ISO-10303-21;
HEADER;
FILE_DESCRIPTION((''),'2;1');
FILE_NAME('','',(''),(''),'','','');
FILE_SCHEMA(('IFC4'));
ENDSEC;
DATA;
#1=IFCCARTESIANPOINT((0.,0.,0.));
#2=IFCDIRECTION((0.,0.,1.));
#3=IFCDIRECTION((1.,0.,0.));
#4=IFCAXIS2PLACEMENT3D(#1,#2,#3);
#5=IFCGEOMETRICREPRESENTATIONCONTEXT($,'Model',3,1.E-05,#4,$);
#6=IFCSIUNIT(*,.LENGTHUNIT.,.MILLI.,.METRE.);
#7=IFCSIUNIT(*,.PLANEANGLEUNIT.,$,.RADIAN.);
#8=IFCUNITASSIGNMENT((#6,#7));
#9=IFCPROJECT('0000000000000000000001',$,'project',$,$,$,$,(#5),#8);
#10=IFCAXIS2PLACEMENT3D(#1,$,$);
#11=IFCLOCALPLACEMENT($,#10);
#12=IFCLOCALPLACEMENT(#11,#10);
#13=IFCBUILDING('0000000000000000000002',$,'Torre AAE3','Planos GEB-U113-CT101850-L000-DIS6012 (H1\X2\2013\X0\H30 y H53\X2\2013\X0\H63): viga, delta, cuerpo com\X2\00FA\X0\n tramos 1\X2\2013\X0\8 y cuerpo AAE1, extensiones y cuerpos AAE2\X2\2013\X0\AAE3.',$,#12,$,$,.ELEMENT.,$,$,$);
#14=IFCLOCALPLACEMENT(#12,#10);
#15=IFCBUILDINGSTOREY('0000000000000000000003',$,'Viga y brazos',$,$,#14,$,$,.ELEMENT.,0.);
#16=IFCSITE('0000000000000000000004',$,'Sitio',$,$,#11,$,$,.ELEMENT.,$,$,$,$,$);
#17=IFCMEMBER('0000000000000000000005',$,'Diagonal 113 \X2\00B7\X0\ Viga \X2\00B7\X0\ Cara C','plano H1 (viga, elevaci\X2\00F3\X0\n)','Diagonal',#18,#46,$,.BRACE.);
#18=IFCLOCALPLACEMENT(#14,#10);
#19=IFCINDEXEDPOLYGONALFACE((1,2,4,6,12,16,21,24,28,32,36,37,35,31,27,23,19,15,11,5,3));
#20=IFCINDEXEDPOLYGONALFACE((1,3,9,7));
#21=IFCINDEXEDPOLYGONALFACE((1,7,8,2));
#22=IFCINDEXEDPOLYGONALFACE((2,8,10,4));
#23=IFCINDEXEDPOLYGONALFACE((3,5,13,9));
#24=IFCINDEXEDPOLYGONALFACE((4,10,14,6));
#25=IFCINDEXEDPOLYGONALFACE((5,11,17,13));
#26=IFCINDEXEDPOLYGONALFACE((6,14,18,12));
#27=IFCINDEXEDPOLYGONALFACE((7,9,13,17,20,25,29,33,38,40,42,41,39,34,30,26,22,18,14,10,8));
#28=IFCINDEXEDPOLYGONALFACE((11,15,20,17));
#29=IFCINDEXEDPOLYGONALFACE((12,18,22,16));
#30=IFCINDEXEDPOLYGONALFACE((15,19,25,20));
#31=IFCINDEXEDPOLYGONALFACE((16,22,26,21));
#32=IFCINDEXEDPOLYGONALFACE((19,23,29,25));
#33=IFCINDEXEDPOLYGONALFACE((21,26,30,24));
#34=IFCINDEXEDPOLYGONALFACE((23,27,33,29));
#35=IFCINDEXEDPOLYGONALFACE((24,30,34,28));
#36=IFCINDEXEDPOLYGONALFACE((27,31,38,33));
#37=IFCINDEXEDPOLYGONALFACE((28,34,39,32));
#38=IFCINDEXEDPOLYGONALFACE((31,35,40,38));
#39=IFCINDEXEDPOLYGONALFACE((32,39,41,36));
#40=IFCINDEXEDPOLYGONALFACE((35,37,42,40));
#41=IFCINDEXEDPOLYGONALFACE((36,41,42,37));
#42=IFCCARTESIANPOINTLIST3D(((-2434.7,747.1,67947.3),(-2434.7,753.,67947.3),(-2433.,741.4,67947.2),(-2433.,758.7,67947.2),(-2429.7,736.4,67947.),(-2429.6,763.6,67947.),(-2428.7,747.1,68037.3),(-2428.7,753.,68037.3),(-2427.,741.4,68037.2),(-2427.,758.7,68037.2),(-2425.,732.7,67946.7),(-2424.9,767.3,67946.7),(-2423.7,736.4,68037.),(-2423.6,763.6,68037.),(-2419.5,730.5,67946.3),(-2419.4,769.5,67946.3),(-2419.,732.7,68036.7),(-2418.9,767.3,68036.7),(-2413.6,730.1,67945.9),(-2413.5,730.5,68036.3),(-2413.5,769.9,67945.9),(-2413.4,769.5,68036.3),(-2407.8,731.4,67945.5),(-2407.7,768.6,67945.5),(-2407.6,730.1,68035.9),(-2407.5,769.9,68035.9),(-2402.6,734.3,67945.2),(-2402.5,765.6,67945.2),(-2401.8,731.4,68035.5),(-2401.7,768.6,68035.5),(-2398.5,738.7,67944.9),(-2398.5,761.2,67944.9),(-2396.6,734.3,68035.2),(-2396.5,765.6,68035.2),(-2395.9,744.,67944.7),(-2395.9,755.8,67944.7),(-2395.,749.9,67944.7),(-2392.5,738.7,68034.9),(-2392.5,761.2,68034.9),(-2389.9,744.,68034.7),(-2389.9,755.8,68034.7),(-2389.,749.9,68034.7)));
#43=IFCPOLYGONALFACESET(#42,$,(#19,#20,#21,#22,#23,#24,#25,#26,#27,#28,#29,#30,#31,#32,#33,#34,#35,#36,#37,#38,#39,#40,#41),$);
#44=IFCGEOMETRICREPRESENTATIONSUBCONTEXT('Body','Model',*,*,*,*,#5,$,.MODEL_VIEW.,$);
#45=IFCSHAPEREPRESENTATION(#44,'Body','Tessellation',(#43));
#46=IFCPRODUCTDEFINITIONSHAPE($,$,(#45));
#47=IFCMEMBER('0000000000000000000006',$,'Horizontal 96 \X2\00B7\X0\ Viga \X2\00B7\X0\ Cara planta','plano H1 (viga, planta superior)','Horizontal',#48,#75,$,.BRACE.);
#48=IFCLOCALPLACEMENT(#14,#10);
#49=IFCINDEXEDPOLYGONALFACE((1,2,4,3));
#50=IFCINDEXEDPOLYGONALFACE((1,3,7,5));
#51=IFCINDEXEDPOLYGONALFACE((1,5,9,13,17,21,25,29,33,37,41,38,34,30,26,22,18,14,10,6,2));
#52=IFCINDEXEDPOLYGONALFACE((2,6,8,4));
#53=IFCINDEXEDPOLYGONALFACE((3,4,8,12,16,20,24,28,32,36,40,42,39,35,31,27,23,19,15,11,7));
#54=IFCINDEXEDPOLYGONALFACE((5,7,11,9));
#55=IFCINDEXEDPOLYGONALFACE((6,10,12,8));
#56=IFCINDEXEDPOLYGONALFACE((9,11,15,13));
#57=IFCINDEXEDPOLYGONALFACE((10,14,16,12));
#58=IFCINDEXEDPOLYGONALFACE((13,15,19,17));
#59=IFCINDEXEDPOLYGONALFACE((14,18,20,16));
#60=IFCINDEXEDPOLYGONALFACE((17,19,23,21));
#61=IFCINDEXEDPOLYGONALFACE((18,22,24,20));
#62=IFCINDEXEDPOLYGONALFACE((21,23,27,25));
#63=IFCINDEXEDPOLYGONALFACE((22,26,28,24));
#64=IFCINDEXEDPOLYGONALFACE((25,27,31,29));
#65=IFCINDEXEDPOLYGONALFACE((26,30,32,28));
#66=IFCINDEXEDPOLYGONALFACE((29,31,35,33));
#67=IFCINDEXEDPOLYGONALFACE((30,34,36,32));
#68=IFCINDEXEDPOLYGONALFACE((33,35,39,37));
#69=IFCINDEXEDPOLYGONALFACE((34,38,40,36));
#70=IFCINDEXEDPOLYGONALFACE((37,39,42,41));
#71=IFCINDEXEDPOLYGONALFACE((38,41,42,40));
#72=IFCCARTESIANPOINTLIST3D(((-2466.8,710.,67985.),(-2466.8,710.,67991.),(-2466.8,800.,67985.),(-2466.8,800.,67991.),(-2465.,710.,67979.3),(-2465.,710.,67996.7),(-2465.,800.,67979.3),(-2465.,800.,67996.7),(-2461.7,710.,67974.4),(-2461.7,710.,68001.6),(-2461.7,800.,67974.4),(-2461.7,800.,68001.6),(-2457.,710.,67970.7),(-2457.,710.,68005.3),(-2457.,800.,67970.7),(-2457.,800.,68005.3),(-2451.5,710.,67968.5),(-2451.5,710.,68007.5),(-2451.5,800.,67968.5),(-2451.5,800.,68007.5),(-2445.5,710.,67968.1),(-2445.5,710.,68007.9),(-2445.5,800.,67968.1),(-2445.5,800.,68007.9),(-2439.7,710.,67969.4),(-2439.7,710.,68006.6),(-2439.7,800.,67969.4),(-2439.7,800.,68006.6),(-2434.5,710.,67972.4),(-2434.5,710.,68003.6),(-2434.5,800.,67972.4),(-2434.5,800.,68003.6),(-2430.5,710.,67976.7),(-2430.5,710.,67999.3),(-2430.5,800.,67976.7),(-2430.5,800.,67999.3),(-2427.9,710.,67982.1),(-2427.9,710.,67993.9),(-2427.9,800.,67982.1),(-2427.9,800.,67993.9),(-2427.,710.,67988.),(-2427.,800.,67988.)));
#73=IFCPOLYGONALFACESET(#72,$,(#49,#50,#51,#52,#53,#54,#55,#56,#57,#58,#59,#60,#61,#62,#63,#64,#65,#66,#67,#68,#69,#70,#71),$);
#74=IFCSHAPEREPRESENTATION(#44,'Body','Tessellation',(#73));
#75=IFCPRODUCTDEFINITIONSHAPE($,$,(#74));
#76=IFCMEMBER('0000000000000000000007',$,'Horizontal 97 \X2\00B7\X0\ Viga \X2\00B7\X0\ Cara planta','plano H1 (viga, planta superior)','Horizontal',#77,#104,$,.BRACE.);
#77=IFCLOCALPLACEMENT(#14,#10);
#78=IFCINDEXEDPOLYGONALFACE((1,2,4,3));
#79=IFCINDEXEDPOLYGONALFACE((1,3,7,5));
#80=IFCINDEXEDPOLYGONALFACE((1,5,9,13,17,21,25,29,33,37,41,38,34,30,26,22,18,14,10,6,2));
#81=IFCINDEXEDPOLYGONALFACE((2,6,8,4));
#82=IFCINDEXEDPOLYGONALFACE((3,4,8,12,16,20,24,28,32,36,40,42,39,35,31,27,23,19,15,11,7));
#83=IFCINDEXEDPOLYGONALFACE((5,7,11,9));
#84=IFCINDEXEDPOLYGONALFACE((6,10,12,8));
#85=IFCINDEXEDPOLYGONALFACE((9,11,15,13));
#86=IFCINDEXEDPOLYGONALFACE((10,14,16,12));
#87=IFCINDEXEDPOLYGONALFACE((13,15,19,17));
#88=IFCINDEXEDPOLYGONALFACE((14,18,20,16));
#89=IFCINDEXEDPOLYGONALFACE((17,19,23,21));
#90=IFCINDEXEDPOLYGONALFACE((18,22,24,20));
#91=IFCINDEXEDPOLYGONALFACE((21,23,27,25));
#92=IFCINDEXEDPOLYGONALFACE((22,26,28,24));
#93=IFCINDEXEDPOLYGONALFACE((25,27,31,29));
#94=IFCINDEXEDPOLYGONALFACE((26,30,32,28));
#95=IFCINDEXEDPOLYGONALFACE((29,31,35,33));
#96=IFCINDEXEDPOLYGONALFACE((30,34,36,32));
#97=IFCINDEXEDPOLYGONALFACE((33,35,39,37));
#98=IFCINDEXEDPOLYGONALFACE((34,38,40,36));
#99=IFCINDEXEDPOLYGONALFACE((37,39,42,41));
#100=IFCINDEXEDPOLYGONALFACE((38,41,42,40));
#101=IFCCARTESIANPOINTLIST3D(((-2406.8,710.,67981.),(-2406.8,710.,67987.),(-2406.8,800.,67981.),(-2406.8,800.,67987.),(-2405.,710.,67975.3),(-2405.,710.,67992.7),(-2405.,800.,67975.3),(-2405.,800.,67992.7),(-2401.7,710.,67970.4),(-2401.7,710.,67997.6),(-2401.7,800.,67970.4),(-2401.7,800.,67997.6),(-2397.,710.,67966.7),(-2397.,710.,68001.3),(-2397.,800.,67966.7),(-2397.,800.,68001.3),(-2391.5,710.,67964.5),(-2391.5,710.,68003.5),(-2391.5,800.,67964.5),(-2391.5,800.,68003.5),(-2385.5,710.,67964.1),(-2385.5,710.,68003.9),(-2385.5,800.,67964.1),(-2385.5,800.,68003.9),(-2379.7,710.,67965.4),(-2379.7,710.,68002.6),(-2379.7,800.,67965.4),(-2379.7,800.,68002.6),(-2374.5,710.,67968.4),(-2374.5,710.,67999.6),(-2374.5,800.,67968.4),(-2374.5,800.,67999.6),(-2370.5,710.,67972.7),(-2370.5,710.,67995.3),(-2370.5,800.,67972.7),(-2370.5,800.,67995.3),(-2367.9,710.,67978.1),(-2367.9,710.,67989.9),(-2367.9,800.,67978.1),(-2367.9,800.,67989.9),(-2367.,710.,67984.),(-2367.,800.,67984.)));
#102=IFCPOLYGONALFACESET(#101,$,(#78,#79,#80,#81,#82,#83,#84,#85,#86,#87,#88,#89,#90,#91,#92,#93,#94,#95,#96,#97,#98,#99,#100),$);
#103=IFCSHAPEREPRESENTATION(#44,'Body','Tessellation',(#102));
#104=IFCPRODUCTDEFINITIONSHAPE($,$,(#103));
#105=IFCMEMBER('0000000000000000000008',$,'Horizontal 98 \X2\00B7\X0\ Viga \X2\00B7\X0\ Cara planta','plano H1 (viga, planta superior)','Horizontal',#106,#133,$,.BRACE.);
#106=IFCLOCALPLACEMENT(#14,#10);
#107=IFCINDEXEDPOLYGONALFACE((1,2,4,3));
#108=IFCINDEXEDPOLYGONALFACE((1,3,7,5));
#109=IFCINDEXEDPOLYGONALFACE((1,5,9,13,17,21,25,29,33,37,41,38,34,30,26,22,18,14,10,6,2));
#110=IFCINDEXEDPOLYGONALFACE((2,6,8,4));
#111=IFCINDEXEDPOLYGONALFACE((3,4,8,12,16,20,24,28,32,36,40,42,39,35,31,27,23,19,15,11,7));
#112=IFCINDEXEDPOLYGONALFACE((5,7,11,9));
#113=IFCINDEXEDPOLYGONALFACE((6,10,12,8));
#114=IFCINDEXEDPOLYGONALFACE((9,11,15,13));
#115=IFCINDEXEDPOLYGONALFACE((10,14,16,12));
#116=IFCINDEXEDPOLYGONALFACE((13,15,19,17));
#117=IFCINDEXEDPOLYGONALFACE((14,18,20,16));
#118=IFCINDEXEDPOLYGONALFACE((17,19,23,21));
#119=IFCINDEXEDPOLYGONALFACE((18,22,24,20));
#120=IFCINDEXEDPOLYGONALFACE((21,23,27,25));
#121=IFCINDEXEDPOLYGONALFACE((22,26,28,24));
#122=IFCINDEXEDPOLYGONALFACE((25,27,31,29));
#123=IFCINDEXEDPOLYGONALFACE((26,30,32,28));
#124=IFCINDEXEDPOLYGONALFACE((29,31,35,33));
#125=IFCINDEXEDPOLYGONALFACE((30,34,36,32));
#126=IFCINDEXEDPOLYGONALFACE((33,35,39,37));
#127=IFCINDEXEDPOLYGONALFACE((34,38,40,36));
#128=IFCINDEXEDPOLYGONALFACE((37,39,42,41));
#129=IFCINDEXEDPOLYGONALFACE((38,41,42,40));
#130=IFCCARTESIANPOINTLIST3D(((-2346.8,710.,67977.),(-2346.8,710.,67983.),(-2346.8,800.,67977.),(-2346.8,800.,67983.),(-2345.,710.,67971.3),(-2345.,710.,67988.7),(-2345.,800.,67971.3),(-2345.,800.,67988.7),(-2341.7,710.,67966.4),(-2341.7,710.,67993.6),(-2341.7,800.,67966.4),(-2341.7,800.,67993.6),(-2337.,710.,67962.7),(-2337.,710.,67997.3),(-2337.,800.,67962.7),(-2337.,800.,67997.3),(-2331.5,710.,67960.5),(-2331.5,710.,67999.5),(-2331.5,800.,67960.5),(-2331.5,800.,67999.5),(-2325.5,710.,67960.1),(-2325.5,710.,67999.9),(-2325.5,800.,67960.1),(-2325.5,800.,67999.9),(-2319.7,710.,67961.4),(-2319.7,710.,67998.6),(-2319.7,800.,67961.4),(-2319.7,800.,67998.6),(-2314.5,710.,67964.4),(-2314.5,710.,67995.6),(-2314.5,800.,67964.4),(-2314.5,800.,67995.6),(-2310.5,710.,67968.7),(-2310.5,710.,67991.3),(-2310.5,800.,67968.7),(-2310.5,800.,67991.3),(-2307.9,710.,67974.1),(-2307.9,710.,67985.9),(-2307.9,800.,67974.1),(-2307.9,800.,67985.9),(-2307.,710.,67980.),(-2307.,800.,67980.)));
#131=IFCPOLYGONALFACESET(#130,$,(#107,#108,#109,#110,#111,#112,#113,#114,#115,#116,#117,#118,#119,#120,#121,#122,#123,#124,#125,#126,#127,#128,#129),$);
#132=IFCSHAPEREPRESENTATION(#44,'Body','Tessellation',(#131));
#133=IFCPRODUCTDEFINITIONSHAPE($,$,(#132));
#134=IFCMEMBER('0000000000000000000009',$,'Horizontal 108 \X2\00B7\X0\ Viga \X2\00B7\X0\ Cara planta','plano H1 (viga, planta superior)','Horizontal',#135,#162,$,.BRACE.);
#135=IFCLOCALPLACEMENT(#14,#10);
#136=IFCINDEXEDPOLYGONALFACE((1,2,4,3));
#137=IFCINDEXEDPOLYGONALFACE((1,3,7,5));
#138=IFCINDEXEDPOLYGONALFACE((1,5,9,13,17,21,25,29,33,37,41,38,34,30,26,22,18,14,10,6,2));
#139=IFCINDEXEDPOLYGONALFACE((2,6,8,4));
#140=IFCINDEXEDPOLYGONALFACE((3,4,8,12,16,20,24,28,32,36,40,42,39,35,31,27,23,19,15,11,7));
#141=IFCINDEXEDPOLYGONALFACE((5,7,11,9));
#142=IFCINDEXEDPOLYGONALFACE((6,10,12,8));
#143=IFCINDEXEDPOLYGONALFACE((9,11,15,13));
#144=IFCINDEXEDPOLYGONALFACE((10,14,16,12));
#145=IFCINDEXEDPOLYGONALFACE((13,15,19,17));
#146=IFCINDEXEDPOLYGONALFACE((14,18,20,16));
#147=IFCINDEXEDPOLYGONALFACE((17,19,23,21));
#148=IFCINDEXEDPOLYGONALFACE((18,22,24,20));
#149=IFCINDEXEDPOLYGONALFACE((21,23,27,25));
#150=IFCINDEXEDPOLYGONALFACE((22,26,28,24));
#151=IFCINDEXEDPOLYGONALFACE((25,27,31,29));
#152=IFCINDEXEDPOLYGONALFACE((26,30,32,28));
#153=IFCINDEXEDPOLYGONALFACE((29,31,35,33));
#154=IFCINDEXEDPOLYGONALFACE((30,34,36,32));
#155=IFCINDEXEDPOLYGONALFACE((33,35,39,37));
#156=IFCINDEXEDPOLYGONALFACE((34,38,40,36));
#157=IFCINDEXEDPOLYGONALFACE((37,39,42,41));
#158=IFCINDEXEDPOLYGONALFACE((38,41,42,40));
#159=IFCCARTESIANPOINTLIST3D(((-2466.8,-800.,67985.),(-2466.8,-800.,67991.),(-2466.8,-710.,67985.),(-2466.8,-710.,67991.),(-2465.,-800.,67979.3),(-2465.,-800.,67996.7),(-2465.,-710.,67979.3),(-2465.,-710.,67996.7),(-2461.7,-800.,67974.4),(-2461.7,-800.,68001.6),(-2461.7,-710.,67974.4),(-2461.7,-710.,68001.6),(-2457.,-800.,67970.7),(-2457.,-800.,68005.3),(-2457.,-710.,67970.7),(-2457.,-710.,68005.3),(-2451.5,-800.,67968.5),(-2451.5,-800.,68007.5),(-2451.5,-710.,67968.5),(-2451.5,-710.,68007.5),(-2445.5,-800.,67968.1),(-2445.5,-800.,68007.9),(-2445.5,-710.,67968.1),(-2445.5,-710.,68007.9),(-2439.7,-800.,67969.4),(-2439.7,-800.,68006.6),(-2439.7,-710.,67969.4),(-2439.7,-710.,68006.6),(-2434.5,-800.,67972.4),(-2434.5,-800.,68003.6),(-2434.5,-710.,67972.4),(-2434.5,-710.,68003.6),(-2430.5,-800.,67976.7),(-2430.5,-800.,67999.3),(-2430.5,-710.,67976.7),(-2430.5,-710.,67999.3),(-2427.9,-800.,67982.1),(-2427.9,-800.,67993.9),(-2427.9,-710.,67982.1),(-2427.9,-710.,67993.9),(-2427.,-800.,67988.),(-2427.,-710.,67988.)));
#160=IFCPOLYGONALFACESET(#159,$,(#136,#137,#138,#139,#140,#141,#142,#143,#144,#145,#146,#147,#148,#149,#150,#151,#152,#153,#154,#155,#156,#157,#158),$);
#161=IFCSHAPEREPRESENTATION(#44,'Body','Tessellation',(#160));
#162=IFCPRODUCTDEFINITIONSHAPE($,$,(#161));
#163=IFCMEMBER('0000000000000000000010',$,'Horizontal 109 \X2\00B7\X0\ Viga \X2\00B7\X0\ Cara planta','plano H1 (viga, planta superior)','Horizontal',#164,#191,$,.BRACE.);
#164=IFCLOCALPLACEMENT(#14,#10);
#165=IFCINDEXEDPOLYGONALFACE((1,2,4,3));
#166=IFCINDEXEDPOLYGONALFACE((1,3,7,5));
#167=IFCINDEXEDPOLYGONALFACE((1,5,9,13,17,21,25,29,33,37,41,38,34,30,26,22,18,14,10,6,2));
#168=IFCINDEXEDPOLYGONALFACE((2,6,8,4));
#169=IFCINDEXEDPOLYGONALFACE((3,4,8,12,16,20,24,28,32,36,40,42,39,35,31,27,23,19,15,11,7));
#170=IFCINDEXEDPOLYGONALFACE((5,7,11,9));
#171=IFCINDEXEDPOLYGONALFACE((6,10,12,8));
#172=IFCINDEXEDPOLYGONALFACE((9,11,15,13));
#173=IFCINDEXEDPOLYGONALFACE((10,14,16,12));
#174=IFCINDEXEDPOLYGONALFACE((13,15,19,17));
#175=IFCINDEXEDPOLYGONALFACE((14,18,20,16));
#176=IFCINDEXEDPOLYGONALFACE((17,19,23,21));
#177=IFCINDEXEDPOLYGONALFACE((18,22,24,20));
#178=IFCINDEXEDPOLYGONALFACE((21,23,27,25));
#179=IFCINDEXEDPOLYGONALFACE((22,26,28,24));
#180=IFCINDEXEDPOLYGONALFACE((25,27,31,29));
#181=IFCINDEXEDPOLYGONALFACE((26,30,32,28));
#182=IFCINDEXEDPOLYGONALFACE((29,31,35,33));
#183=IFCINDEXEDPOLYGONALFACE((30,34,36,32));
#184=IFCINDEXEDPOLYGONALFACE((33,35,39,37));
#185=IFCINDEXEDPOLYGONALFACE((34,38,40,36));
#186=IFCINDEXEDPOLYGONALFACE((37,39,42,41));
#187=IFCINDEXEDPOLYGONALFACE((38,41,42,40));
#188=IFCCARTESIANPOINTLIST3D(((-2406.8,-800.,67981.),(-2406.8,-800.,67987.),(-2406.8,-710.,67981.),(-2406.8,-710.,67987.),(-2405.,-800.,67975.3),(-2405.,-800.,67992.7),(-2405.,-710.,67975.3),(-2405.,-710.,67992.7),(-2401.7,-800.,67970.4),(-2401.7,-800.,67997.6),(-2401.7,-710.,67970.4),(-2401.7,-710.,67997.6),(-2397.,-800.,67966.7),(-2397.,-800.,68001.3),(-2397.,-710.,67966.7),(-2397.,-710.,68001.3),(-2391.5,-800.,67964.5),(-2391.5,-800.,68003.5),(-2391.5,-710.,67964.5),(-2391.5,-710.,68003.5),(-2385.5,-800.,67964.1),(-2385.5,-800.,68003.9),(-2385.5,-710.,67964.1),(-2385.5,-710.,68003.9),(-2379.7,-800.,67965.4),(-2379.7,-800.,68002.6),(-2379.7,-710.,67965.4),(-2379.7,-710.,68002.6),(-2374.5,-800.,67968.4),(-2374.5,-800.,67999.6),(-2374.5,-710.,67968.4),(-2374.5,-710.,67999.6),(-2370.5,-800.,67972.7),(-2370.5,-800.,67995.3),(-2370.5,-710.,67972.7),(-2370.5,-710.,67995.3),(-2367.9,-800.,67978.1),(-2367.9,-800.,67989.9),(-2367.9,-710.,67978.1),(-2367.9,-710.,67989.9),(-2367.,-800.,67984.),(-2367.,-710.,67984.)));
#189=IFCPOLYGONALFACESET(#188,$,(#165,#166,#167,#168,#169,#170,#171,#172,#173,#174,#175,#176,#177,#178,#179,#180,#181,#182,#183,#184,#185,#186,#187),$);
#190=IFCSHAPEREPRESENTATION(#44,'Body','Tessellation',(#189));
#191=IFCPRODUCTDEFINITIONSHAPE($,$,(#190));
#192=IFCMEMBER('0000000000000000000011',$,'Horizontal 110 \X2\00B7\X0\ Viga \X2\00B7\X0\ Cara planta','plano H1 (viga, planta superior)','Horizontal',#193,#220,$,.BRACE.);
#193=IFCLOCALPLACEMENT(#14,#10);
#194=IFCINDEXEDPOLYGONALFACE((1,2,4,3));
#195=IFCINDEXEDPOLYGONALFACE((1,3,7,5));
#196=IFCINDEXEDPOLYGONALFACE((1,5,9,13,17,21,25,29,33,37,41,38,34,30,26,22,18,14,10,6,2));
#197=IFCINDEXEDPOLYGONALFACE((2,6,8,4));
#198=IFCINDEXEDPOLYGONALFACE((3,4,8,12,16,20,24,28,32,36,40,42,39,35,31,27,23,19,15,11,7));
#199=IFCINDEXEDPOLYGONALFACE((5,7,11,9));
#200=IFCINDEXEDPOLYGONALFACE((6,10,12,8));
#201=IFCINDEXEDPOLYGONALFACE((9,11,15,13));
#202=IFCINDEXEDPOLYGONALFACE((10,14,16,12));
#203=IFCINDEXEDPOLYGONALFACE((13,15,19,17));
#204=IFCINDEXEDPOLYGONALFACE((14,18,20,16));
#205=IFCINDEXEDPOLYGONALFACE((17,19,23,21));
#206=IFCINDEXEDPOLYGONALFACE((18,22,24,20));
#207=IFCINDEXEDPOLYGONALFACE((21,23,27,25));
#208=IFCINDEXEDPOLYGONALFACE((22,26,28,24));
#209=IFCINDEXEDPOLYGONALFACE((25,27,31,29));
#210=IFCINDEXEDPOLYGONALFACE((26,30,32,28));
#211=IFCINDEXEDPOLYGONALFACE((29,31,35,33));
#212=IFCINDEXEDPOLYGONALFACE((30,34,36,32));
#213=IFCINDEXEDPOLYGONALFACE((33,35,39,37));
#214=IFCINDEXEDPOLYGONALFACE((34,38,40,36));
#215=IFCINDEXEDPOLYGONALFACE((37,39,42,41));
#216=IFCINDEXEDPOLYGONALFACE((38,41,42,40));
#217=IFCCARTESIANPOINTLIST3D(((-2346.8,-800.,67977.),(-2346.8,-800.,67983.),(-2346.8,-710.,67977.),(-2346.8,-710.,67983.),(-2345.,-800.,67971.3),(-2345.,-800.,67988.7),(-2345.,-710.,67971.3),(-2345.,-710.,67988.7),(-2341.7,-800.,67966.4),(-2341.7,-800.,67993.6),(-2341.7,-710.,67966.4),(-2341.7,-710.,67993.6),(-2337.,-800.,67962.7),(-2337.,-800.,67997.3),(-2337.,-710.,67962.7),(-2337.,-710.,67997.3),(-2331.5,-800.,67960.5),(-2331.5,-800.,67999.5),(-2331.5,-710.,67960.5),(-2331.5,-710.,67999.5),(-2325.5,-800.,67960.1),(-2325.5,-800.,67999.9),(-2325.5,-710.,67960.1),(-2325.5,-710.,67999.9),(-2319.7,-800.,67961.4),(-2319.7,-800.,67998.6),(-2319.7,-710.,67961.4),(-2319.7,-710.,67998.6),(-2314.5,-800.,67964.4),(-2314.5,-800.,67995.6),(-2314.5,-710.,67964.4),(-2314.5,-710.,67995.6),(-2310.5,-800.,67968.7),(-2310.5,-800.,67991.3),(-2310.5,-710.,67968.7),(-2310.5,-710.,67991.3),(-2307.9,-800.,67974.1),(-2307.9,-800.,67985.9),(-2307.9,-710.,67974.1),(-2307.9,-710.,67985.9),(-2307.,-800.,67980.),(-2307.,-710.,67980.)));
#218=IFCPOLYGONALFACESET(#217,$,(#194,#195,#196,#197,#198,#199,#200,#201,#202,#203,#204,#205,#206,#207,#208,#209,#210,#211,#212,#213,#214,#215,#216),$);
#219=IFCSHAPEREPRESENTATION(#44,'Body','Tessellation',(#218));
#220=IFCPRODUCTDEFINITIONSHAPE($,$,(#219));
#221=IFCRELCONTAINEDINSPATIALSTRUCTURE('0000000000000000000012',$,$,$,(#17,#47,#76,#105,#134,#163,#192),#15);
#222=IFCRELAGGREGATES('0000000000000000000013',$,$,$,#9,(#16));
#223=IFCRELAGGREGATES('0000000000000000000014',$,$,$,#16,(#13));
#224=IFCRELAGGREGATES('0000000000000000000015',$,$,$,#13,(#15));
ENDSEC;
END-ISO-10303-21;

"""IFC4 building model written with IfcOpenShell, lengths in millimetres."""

from ifc_helpers import new_model, si_unit, frame, origin, origin_with_axes, place, context, subcontext, project, spatial, circle, extrude, element, save


model = new_model("IFC4")

# Units and contexts
model_context = context("Model", 3, precision=1e-05, world=origin_with_axes())
body_context = subcontext(model_context, "Body", "Model", "MODEL_VIEW")
ifc_project = project(units=[si_unit("LENGTHUNIT", "METRE", prefix="MILLI"), si_unit("PLANEANGLEUNIT", "RADIAN")], contexts=[model_context])

# Site, building, storey
site_placement = place(None, origin())
site = spatial("IfcSite", under=ifc_project, at=site_placement, Name="Sitio", CompositionType="ELEMENT")
building_placement = place(site_placement, origin())
building = spatial("IfcBuilding", under=site, at=building_placement, Name="Torre AAE3", Description="Planos GEB-U113-CT101850-L000-DIS6012 (H1–H30 y H53–H63): viga, delta, cuerpo común tramos 1–8 y cuerpo AAE1, extensiones y cuerpos AAE2–AAE3.", CompositionType="ELEMENT")
storey_placement = place(building_placement, origin())
storey = spatial("IfcBuildingStorey", under=building, at=storey_placement, Name="Viga y brazos", CompositionType="ELEMENT", Elevation=0.0)

# Members
for number, where, z_axis, x_axis, name in (
    (1, (-2415.0, 750.0, 67946.0), (0.066519, 0.0, 0.997785), (0.9526, -0.297523, -0.063507), "Diagonal 113 · Viga · Cara C"),
):
    element("IfcMember", number, at=place(storey_placement, frame(where, z_axis=z_axis, x_axis=x_axis)), inside=storey, Name=name, Description="plano H1 (viga, elevación)", ObjectType="Diagonal", PredefinedType="BRACE", context=body_context, shape_type="SweptSolid", body=[
        extrude(circle(Radius=20.0), None, (0.0, 0.0, 1.0), 90.2),
    ])
for number, where, z_axis, x_axis, name in (
    (2, (-2447.0, 710.0, 67988.0), (0.0, 1.0, 0.0), (1.0, 0.0, 0.0), "Horizontal 96 · Viga · Cara planta"),
    (3, (-2387.0, 710.0, 67984.0), (0.0, 1.0, 0.0), (1.0, 0.0, 0.0), "Horizontal 97 · Viga · Cara planta"),
    (4, (-2327.0, 710.0, 67980.0), (0.0, 1.0, 0.0), (1.0, 0.0, 0.0), "Horizontal 98 · Viga · Cara planta"),
    (5, (-2447.0, -710.0, 67988.0), (0.0, -1.0, 0.0), (1.0, 0.0, 0.0), "Horizontal 108 · Viga · Cara planta"),
    (6, (-2387.0, -710.0, 67984.0), (0.0, -1.0, 0.0), (1.0, 0.0, 0.0), "Horizontal 109 · Viga · Cara planta"),
    (7, (-2327.0, -710.0, 67980.0), (0.0, -1.0, 0.0), (1.0, 0.0, 0.0), "Horizontal 110 · Viga · Cara planta"),
):
    element("IfcMember", number, at=place(storey_placement, frame(where, z_axis=z_axis, x_axis=x_axis)), inside=storey, Name=name, Description="plano H1 (viga, planta superior)", ObjectType="Horizontal", PredefinedType="BRACE", context=body_context, shape_type="SweptSolid", body=[
        extrude(circle(Radius=20.0), None, (0.0, 0.0, 1.0), 90.0),
    ])

save(model, "model.ifc")
